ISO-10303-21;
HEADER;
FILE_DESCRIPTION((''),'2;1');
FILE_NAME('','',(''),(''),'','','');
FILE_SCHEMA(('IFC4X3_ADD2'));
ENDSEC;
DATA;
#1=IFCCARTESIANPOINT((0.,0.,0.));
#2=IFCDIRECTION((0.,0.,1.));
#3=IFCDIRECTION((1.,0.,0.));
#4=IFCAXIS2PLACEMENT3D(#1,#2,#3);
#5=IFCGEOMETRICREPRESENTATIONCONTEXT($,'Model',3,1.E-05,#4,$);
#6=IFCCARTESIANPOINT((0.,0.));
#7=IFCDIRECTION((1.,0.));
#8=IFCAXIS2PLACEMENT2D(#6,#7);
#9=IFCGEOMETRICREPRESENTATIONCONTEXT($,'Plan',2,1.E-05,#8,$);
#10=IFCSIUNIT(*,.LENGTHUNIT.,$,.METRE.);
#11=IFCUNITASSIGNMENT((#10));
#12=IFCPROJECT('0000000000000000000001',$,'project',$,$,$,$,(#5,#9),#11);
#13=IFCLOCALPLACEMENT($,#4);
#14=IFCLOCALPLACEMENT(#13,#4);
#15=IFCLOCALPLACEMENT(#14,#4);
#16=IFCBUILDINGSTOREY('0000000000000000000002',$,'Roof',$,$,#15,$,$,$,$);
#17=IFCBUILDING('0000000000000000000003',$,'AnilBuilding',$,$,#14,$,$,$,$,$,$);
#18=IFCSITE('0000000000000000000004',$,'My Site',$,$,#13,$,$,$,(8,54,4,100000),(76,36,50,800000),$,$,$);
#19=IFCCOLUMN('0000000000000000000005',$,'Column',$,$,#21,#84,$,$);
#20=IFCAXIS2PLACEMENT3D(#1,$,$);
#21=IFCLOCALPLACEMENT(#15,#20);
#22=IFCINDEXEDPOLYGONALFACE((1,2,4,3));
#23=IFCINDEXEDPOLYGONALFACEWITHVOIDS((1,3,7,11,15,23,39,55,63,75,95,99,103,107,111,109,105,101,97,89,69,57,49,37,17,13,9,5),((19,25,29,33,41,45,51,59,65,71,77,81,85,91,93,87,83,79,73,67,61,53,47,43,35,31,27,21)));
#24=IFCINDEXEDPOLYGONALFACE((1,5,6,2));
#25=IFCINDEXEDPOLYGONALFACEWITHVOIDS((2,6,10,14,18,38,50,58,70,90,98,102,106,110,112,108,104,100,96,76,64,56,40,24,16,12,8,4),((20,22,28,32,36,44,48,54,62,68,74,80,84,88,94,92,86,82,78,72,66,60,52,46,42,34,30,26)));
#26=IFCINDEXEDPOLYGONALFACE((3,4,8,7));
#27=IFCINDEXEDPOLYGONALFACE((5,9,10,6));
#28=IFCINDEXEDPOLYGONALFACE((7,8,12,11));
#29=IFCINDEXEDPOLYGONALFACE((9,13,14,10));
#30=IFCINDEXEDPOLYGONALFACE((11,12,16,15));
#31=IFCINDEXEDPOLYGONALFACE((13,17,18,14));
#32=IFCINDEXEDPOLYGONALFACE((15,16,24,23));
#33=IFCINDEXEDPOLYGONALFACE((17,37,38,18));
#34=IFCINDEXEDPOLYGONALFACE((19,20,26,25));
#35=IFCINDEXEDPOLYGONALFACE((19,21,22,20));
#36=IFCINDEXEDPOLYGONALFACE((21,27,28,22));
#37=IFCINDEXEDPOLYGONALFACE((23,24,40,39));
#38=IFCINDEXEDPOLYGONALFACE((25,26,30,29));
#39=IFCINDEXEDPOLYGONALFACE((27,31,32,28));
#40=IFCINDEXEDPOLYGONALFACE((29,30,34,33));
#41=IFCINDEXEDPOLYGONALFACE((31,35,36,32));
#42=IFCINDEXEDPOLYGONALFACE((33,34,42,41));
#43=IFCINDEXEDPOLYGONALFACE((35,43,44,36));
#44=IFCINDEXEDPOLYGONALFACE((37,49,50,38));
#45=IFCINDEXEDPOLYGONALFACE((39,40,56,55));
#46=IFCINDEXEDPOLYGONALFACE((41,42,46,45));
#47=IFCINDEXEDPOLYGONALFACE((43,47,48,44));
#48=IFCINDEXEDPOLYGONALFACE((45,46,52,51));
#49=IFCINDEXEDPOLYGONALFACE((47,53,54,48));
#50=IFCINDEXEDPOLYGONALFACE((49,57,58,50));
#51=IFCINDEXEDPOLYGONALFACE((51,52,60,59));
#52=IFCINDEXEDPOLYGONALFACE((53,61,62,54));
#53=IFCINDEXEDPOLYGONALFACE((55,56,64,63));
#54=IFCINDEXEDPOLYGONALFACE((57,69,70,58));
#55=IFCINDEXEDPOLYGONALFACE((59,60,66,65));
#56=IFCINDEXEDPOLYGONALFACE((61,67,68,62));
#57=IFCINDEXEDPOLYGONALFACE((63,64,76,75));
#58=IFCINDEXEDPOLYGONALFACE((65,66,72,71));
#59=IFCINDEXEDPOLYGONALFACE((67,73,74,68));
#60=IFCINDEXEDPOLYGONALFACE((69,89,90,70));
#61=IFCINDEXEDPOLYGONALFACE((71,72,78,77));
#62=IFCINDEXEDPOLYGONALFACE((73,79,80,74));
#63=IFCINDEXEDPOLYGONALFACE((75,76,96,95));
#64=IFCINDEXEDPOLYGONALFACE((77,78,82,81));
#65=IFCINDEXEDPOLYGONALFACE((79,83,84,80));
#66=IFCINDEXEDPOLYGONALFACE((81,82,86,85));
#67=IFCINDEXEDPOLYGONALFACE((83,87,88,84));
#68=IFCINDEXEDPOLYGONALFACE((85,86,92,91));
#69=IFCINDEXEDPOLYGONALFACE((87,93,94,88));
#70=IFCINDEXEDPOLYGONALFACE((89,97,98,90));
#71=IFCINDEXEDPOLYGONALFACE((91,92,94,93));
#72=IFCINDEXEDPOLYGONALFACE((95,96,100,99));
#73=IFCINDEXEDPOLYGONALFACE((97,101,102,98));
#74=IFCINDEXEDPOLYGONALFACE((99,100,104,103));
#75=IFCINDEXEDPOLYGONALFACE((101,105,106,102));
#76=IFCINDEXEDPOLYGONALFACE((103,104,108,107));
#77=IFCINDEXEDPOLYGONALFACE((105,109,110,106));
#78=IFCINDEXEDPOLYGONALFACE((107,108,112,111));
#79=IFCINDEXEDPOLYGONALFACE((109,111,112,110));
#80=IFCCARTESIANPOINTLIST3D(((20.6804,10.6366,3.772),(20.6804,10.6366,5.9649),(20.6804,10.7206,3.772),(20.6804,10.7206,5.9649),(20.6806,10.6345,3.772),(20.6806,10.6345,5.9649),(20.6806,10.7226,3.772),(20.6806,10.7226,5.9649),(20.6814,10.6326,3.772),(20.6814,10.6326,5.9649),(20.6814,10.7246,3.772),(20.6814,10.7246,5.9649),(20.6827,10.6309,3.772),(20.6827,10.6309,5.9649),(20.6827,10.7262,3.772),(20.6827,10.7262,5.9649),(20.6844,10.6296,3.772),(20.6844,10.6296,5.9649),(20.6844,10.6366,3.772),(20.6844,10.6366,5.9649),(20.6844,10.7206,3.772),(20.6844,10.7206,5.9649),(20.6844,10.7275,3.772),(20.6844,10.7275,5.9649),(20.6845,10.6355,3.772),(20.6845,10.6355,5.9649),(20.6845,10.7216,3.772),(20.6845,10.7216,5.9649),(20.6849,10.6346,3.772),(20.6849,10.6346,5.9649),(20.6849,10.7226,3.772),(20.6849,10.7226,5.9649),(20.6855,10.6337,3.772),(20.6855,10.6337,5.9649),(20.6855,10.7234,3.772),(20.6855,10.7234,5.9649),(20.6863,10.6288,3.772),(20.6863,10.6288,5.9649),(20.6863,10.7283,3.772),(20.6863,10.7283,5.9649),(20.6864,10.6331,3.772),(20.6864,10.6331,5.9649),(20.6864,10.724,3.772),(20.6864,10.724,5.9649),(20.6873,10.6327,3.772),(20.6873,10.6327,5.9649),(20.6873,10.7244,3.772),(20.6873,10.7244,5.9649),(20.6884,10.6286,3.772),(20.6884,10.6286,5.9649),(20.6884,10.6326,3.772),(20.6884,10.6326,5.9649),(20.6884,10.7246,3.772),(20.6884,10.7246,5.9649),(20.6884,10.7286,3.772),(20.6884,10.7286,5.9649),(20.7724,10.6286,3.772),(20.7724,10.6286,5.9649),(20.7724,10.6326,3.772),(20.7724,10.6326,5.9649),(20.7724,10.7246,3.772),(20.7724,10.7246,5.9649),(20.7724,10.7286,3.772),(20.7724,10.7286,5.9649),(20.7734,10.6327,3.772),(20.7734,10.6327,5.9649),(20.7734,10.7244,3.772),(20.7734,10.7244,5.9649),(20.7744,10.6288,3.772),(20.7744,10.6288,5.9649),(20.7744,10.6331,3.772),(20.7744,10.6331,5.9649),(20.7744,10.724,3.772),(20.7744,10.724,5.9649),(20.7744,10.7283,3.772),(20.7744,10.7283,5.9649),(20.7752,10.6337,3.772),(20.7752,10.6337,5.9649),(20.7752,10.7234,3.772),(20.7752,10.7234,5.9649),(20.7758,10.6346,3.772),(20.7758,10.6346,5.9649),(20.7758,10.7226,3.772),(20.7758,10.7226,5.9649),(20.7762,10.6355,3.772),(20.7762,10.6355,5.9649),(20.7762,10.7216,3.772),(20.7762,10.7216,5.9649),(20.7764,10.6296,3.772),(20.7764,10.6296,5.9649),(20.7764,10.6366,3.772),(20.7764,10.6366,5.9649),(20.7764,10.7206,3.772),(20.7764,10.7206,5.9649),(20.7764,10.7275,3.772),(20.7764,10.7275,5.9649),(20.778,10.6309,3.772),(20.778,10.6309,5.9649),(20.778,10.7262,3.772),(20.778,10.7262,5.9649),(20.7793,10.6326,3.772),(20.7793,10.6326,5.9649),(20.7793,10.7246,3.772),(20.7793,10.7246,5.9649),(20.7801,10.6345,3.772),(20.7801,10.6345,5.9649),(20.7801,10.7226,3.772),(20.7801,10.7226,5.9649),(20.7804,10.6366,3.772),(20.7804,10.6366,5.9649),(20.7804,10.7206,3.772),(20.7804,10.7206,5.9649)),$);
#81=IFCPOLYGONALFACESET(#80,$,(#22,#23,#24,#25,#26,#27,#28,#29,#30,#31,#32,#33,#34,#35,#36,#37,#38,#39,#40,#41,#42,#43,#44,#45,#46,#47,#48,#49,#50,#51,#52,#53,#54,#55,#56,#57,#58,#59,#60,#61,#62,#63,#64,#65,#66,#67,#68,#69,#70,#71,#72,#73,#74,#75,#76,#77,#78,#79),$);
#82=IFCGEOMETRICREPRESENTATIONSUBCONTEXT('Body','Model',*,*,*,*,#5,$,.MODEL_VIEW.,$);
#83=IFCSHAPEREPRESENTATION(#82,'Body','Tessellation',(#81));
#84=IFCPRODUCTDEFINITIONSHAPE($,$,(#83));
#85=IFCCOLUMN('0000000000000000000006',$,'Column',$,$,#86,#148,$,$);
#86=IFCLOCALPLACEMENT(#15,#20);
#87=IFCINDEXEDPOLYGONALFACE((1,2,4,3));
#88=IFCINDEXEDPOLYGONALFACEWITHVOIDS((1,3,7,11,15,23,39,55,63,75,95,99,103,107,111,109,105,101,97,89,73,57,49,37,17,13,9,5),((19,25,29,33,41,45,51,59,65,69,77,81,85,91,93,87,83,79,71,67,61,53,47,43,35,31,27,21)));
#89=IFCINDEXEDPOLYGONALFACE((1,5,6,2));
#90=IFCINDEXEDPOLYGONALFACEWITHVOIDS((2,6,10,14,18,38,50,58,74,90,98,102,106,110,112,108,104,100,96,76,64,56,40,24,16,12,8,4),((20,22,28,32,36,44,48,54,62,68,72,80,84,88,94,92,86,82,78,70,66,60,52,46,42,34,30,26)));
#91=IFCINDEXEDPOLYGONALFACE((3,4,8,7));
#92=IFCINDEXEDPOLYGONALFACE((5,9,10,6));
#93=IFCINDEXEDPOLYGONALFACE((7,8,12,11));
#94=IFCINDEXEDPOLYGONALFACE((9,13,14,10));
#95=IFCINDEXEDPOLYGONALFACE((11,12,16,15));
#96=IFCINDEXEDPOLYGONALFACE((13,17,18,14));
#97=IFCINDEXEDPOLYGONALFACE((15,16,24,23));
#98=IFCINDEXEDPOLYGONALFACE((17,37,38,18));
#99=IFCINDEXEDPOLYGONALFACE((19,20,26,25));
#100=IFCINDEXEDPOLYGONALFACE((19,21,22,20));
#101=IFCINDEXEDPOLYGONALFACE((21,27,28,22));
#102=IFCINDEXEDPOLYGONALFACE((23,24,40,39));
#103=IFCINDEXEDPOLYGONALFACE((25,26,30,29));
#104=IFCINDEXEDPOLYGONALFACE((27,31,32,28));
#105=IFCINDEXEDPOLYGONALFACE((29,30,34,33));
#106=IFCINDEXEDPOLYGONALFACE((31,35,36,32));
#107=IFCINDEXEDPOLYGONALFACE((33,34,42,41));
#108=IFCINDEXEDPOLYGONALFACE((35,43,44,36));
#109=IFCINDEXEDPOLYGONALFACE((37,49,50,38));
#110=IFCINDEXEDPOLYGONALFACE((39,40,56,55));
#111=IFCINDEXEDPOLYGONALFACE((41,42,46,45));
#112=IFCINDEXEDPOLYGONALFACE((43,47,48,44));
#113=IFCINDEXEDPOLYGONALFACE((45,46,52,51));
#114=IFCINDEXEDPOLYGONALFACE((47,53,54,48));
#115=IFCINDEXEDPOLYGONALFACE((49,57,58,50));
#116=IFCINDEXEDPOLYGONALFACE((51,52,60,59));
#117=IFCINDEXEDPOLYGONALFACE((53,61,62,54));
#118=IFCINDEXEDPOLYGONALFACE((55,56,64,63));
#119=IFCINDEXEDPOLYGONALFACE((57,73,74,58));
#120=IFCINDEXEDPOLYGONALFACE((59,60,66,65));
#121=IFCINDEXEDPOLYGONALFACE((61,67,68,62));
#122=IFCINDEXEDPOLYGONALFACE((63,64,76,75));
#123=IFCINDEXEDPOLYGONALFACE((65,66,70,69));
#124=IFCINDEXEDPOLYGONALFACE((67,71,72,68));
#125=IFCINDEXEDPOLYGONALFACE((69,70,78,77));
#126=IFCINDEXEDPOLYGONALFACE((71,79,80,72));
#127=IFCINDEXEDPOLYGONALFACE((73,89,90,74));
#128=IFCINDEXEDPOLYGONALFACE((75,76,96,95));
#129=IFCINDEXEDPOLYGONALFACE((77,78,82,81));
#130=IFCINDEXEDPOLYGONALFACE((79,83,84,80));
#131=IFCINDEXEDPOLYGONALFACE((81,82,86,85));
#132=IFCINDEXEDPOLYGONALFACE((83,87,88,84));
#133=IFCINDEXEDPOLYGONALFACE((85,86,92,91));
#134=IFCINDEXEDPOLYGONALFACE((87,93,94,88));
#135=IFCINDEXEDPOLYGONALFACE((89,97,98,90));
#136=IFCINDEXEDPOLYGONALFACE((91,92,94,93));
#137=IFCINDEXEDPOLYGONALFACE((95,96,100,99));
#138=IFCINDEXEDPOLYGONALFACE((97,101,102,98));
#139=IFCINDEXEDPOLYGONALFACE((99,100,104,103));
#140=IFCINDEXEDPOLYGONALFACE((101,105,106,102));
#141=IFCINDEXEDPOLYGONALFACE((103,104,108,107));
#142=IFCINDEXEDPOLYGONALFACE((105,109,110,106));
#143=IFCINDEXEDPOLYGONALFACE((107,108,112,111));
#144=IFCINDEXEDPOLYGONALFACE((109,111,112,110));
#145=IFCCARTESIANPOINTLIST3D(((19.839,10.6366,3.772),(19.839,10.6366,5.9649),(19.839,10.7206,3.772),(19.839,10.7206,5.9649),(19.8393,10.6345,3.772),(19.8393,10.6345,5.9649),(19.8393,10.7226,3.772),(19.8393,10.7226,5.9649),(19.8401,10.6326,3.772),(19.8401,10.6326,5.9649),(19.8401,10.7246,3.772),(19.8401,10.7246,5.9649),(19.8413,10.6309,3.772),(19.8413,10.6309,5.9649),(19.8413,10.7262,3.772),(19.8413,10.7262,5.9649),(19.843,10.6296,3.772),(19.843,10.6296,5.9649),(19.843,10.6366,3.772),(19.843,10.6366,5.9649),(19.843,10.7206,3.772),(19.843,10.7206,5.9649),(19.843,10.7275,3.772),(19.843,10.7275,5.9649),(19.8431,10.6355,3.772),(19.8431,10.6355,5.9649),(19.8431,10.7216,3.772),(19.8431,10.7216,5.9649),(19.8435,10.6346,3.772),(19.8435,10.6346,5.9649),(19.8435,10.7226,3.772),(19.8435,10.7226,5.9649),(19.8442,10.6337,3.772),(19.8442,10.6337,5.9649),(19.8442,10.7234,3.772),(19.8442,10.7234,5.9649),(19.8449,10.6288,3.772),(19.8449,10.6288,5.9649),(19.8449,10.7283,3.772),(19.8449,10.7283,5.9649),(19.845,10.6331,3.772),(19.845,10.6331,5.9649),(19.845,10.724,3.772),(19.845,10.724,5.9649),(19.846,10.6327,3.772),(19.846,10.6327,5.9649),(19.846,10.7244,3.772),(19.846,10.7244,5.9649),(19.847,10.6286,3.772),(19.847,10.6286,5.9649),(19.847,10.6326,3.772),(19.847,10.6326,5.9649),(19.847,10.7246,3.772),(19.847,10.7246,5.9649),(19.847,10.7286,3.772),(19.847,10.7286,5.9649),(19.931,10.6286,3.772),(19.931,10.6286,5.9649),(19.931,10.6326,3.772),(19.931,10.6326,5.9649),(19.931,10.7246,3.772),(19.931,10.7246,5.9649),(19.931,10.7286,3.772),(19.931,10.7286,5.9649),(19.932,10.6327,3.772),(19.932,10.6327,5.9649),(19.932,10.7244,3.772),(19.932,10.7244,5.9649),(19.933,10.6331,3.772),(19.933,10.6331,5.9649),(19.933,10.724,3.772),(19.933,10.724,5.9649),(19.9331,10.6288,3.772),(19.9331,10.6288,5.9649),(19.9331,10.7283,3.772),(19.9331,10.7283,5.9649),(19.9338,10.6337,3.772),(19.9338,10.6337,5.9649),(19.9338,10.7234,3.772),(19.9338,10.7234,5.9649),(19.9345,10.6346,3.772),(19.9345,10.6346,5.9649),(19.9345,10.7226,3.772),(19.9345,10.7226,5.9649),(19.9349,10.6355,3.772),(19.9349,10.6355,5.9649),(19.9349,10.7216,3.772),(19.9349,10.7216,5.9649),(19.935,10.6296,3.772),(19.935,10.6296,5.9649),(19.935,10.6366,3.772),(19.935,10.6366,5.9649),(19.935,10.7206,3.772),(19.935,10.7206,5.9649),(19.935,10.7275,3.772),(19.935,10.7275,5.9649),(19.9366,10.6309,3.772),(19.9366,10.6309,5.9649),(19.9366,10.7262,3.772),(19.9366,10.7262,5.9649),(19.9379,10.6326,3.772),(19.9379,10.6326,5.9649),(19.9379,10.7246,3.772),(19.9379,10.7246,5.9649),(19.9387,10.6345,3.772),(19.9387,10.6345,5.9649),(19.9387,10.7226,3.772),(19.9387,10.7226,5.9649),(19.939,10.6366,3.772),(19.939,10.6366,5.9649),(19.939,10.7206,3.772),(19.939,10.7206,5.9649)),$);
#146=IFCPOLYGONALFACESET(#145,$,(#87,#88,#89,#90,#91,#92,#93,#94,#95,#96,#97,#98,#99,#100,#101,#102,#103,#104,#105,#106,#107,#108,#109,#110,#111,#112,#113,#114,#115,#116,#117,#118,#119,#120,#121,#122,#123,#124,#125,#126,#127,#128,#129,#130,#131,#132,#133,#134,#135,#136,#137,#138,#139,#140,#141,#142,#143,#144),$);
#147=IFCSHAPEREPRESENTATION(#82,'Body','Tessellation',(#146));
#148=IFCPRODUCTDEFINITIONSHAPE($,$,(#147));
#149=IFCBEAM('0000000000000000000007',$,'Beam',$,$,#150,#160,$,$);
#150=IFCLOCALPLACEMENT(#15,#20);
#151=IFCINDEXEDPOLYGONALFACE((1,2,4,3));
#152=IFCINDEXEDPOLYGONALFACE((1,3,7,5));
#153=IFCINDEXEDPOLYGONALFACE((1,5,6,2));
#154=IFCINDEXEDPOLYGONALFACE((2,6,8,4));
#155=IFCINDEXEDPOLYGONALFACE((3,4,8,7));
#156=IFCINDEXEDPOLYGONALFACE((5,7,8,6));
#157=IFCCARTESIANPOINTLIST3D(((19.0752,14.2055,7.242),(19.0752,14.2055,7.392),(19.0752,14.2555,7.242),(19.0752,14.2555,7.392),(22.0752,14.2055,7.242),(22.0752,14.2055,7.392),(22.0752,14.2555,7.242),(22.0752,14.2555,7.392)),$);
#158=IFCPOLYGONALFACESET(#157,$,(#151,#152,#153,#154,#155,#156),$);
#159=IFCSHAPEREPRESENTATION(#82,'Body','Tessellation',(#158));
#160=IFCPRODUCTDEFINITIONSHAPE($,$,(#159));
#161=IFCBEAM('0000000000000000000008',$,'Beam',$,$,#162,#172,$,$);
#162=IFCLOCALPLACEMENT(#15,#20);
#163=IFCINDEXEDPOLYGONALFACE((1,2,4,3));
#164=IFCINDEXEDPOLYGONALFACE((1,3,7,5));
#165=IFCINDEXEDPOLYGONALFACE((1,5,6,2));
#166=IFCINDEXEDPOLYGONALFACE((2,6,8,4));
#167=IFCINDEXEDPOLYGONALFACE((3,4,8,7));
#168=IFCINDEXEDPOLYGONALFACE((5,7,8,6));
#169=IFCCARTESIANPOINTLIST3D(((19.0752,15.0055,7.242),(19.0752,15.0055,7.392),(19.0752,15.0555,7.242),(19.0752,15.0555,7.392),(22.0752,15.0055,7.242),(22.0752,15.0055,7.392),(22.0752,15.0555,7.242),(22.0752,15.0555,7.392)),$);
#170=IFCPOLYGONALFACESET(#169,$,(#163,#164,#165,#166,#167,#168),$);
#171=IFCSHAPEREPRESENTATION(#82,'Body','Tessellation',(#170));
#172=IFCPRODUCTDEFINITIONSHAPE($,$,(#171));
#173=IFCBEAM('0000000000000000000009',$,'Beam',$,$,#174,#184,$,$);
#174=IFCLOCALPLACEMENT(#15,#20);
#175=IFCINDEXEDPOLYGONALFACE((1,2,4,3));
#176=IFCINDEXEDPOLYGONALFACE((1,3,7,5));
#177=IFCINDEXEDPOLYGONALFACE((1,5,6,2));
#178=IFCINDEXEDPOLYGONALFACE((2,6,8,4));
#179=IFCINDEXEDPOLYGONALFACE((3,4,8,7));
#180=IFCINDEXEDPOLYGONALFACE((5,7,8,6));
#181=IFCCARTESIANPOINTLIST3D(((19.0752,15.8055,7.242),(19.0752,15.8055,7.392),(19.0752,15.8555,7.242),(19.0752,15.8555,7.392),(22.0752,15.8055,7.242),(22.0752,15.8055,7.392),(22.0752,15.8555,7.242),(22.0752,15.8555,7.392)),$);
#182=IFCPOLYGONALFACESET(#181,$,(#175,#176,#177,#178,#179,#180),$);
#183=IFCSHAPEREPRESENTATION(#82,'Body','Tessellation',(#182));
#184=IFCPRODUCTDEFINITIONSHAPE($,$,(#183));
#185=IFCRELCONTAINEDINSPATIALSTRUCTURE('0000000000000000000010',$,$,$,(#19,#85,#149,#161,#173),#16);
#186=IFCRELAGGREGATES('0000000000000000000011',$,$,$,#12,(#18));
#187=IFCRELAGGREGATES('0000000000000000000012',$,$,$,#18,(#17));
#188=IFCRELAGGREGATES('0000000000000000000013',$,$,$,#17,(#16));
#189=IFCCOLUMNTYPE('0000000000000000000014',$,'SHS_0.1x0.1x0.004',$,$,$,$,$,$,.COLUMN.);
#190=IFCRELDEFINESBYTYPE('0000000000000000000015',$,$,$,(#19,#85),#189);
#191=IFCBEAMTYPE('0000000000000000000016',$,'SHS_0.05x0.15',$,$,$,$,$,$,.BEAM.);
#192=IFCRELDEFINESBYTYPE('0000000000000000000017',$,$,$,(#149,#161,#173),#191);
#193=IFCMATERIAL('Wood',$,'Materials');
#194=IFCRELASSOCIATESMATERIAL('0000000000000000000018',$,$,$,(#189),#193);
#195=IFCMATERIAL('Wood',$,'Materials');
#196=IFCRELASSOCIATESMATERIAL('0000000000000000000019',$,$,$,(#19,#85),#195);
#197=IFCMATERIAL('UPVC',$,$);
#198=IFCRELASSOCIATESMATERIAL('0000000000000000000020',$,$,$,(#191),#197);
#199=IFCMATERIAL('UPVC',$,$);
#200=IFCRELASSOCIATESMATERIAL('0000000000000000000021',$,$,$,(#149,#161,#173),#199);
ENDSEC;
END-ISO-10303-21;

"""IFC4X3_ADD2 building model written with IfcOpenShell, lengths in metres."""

from ifc_helpers import new_model, entity, si_unit, frame, origin_with_axes, origin_2d_with_axis, place, context, subcontext, project, spatial, indexed_curve, hollow_rectangle, outline, extrude, shape, material, material_profile, profile_set, profile_usage, type_object, element, save


model = new_model("IFC4X3_ADD2")

# Units and contexts
model_context = context("Model", 3, precision=1e-05, world=origin_with_axes())
plan_context = context("Plan", 2, precision=1e-05, world=origin_2d_with_axis())
body_context_1 = subcontext(model_context, "Body", "Model", "MODEL_VIEW")
body_context_2 = subcontext(plan_context, "Body", "Plan", "PLAN_VIEW")
ifc_project = project(units=[si_unit("LENGTHUNIT", "METRE")], contexts=[model_context, plan_context])

# Site, building, storey
site_placement = place(None, origin_with_axes())
site = spatial("IfcSite", under=ifc_project, at=site_placement, Name="My Site", RefLatitude=(8, 54, 4, 100000), RefLongitude=(76, 36, 50, 800000))
building_placement = place(site_placement, origin_with_axes())
building = spatial("IfcBuilding", under=site, at=building_placement, Name="AnilBuilding")
storey_placement = place(building_placement, origin_with_axes())
storey = spatial("IfcBuildingStorey", under=building, at=storey_placement, Name="Roof")

# Columns
ifc_material_1 = material(Name="UPVC")
ifc_material_2 = material(Name="Wood", Category="Materials")
ifc_material_profile_1 = material_profile(ifc_material_2, hollow_rectangle(XDim=0.1, YDim=0.1, WallThickness=0.004, InnerFilletRadius=0.004, OuterFilletRadius=0.008))
ifc_profile_set_1 = profile_set([ifc_material_profile_1])
column_type_1 = type_object("IfcColumnType", Name="SHS_0.1x0.1x0.004", PredefinedType="COLUMN", material=ifc_profile_set_1)
ifc_material_3 = material(Name="Wood", Category="Materials")
ifc_material_profile_2 = material_profile(ifc_material_3, hollow_rectangle(XDim=0.1, YDim=0.1, WallThickness=0.004, InnerFilletRadius=0.004, OuterFilletRadius=0.008))
ifc_profile_set_2 = profile_set([ifc_material_profile_2])
ifc_profile_usage_1 = profile_usage(ifc_profile_set_2)
column_1_placement = place(storey_placement, frame((20.7304, 10.6786, 3.772), z_axis=(0.0, 0.0, 1.0), x_axis=(0.0, -1.0, 0.0)))
element("IfcColumn", 1, at=column_1_placement, inside=storey, type_object=column_type_1, material=ifc_profile_usage_1, Name="Column", shapes=[
    shape(body_context_1, "Body", "SweptSolid", [extrude(hollow_rectangle(XDim=0.1, YDim=0.1, WallThickness=0.004, InnerFilletRadius=0.004, OuterFilletRadius=0.008), origin_with_axes(), (0.0, 0.0, 1.0), 2.1929)]),
    shape(body_context_2, "Body", "Annotation2D", [entity("IfcGeometricCurveSet", [entity("IfcIndexedPolyCurve", entity("IfcCartesianPointList2D", [[0.04, -0.04], [0.04, 0.04], [-0.04, 0.04], [-0.04, -0.04]]), [entity("IfcLineIndex", [1, 2, 3, 4, 1])]), entity("IfcIndexedPolyCurve", entity("IfcCartesianPointList2D", [[-0.05, -0.05], [0.05, -0.05], [0.05, 0.05], [-0.05, 0.05]]), [entity("IfcLineIndex", [1, 2, 3, 4, 1])])])]),
])
ifc_profile_usage_2 = profile_usage(ifc_profile_set_2)
column_2_placement = place(storey_placement, frame((19.889, 10.6786, 3.772), z_axis=(0.0, 0.0, 1.0), x_axis=(0.0, -1.0, 0.0)))
element("IfcColumn", 2, at=column_2_placement, inside=storey, type_object=column_type_1, material=ifc_profile_usage_2, Name="Column", shapes=[
    shape(body_context_1, "Body", "SweptSolid", [extrude(hollow_rectangle(XDim=0.1, YDim=0.1, WallThickness=0.004, InnerFilletRadius=0.004, OuterFilletRadius=0.008), origin_with_axes(), (0.0, 0.0, 1.0), 2.1929)]),
    shape(body_context_2, "Body", "Annotation2D", [entity("IfcGeometricCurveSet", [entity("IfcIndexedPolyCurve", entity("IfcCartesianPointList2D", [[0.04, -0.04], [0.04, 0.04], [-0.04, 0.04], [-0.04, -0.04]]), [entity("IfcLineIndex", [1, 2, 3, 4, 1])]), entity("IfcIndexedPolyCurve", entity("IfcCartesianPointList2D", [[-0.05, -0.05], [0.05, -0.05], [0.05, 0.05], [-0.05, 0.05]]), [entity("IfcLineIndex", [1, 2, 3, 4, 1])])])]),
])

# Beams
ifc_material_4 = material(Name="UPVC")
ifc_material_profile_3 = material_profile(ifc_material_4, outline(indexed_curve([(-0.025, 0.075), (0.025, 0.075), (0.025, -0.075), (-0.025, -0.075), (-0.025, 0.075)])))
ifc_profile_set_3 = profile_set([ifc_material_profile_3])
ifc_profile_usage_3 = profile_usage(ifc_profile_set_3, cardinal=5)
ifc_material_profile_4 = material_profile(ifc_material_1, outline(indexed_curve([(-0.025, 0.075), (0.025, 0.075), (0.025, -0.075), (-0.025, -0.075), (-0.025, 0.075)])))
ifc_profile_set_4 = profile_set([ifc_material_profile_4])
beam_type = type_object("IfcBeamType", Name="SHS_0.05x0.15", PredefinedType="BEAM", material=ifc_profile_set_4)
beam_1_placement = place(storey_placement, frame((19.0752, 14.2305, 7.317), z_axis=(1.0, 0.0, 0.0), x_axis=(0.0, 1.0, 0.0)))
element("IfcBeam", 3, at=beam_1_placement, inside=storey, type_object=beam_type, material=ifc_profile_usage_3, Name="Beam", context=body_context_1, shape_type="SweptSolid", body=[
    extrude(outline(indexed_curve([(-0.025, 0.075), (0.025, 0.075), (0.025, -0.075), (-0.025, -0.075), (-0.025, 0.075)])), origin_with_axes(), (0.0, 0.0, 1.0), 3.0),
])
ifc_profile_usage_4 = profile_usage(ifc_profile_set_3, cardinal=5)
beam_2_placement = place(storey_placement, frame((19.0752, 15.0305, 7.317), z_axis=(1.0, 0.0, 0.0), x_axis=(0.0, 1.0, 0.0)))
element("IfcBeam", 4, at=beam_2_placement, inside=storey, type_object=beam_type, material=ifc_profile_usage_4, Name="Beam", context=body_context_1, shape_type="SweptSolid", body=[
    extrude(outline(indexed_curve([(-0.025, 0.075), (0.025, 0.075), (0.025, -0.075), (-0.025, -0.075), (-0.025, 0.075)])), origin_with_axes(), (0.0, 0.0, 1.0), 3.0),
])
ifc_profile_usage_5 = profile_usage(ifc_profile_set_3, cardinal=5)
beam_3_placement = place(storey_placement, frame((19.0752, 15.8305, 7.317), z_axis=(1.0, 0.0, 0.0), x_axis=(0.0, 1.0, 0.0)))
element("IfcBeam", 5, at=beam_3_placement, inside=storey, type_object=beam_type, material=ifc_profile_usage_5, Name="Beam", context=body_context_1, shape_type="SweptSolid", body=[
    extrude(outline(indexed_curve([(-0.025, 0.075), (0.025, 0.075), (0.025, -0.075), (-0.025, -0.075), (-0.025, 0.075)])), origin_with_axes(), (0.0, 0.0, 1.0), 3.0),
])

save(model, "model.ifc")
